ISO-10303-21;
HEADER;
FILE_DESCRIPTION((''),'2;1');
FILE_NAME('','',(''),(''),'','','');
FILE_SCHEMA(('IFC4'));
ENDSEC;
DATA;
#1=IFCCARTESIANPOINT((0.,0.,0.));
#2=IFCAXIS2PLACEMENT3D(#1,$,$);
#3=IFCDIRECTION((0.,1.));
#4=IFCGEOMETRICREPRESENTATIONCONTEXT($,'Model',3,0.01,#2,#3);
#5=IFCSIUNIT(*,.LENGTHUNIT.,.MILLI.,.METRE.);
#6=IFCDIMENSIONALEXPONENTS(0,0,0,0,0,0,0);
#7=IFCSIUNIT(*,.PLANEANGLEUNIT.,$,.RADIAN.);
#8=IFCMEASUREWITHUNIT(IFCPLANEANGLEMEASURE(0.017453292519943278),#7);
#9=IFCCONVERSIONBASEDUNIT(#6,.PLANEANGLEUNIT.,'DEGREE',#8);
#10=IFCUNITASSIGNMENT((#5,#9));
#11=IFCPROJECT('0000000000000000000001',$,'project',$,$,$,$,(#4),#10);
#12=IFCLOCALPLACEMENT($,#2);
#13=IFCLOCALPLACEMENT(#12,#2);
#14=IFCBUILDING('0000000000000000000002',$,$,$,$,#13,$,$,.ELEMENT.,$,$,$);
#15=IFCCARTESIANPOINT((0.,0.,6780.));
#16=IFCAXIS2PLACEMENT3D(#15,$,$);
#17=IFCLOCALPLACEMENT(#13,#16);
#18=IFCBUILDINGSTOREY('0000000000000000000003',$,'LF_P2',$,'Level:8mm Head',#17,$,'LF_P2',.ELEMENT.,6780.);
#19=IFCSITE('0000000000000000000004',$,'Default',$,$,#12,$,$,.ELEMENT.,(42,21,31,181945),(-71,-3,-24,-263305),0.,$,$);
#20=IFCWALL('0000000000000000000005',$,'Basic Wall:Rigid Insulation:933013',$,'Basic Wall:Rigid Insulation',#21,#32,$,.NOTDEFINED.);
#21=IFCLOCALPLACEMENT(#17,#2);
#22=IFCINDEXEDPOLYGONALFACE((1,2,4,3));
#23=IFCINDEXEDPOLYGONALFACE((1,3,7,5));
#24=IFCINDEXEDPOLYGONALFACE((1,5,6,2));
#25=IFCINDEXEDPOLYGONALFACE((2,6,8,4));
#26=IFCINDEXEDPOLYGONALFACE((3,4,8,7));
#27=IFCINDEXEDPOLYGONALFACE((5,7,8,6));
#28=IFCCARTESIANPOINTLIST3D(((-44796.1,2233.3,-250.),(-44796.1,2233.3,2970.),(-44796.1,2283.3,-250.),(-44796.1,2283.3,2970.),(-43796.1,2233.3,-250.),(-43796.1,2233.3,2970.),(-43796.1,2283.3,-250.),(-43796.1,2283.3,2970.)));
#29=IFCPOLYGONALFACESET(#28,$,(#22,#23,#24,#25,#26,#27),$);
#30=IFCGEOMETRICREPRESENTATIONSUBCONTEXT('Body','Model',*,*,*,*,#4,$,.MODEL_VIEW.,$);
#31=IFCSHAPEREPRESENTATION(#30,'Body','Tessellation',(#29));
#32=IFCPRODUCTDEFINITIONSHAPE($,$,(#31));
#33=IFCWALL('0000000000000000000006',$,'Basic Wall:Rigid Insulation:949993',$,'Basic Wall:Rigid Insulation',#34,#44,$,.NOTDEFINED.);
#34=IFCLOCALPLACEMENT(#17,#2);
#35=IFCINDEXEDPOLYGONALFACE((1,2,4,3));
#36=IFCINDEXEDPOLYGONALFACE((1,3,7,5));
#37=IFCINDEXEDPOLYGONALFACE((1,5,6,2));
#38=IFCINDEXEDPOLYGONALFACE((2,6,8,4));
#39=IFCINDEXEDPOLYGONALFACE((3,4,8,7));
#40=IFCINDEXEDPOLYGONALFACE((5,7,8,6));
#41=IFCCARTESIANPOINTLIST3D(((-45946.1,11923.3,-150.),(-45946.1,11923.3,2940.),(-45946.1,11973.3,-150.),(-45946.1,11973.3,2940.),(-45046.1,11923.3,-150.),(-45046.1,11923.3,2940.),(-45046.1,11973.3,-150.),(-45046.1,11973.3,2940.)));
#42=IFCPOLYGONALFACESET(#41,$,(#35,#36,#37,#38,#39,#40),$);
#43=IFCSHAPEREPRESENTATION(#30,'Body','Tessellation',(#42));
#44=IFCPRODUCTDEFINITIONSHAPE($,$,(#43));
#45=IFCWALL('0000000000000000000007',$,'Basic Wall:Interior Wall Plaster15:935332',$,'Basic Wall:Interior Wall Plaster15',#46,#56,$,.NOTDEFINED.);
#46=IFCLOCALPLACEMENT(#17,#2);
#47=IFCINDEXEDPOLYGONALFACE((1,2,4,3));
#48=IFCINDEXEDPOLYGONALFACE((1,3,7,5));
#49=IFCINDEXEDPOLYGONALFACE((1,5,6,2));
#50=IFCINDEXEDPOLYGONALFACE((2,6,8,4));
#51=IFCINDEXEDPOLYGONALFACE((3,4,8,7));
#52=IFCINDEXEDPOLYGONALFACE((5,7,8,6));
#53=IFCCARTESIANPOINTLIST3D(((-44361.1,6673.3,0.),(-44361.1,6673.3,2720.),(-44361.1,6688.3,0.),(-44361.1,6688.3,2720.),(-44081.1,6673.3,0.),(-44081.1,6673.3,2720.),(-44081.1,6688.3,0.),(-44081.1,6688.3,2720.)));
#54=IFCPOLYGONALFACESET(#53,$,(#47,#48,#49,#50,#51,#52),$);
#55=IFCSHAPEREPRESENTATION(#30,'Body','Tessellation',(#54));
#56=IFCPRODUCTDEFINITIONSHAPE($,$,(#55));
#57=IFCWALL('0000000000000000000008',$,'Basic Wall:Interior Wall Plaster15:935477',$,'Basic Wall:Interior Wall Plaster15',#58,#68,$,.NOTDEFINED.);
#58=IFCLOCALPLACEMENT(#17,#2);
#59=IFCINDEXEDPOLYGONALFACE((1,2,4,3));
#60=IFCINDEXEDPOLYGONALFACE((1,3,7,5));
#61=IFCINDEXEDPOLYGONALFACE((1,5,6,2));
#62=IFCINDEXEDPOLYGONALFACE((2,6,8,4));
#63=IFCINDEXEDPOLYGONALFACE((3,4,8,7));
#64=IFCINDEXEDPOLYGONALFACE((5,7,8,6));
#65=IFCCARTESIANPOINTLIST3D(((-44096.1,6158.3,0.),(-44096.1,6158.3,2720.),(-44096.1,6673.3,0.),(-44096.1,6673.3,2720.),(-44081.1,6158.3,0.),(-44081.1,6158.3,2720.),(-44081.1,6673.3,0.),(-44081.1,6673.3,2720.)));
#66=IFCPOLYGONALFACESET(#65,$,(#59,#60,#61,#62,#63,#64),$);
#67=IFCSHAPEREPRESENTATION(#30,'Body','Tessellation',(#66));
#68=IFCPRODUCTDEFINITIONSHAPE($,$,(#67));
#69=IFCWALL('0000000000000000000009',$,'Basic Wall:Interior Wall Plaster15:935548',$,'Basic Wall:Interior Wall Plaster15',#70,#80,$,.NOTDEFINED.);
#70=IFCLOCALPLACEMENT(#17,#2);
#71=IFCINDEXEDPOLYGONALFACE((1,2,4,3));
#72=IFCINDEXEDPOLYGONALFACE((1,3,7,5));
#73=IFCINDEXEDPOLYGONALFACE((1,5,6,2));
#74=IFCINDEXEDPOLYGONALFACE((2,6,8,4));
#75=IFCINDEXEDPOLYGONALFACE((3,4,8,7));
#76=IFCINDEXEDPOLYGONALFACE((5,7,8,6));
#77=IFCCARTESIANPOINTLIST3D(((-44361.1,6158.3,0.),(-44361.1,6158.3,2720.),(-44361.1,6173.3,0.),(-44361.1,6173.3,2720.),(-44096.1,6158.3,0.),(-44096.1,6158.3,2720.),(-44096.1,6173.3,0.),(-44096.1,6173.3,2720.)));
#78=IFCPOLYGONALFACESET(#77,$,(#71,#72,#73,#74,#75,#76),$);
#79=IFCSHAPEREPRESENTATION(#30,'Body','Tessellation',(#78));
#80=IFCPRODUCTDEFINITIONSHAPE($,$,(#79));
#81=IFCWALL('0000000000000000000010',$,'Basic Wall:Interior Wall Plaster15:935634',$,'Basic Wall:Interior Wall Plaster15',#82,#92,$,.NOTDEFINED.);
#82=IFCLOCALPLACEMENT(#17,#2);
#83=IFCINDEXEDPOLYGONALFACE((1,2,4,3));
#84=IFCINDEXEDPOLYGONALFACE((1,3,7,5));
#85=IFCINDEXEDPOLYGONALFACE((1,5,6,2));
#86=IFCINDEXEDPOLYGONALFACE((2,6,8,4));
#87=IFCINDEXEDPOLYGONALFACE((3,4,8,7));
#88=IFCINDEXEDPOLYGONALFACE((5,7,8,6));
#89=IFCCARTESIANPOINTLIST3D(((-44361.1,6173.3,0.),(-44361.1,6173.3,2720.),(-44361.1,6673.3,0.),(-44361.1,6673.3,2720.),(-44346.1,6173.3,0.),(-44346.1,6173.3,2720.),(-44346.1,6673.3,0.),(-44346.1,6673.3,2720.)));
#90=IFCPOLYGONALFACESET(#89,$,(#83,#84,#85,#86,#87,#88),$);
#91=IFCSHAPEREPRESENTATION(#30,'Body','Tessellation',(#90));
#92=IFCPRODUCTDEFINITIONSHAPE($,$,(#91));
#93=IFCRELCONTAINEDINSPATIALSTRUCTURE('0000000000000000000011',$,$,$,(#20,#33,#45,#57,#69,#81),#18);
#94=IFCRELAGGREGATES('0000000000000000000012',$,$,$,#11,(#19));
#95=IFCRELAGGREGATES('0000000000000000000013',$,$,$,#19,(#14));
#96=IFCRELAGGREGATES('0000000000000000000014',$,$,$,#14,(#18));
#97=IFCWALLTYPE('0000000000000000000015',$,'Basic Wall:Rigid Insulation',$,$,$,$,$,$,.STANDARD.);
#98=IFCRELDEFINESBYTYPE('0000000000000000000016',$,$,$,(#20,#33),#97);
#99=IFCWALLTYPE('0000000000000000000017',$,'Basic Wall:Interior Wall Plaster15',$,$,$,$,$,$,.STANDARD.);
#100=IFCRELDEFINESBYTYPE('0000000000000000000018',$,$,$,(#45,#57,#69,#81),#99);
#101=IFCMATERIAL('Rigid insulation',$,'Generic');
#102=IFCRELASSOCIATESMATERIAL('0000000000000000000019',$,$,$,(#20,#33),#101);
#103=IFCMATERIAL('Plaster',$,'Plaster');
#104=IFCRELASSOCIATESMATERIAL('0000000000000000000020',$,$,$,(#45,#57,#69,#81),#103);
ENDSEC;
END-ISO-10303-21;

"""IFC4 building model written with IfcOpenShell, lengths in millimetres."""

from ifc_helpers import new_model, entity, si_unit, converted_unit, direction, frame, origin, place, context, subcontext, project, spatial, indexed_curve, outline, extrude, material, type_object, element, save


model = new_model("IFC4")

# Units and contexts
model_context = context("Model", 3, precision=0.01, world=origin(), true_north=direction((0.0, 1.0)))
body_context = subcontext(model_context, "Body", "Model", "MODEL_VIEW")
ifc_project = project(units=[si_unit("LENGTHUNIT", "METRE", prefix="MILLI"), converted_unit("PLANEANGLEUNIT", "DEGREE", entity("IfcPlaneAngleMeasure", 0.017453292519943278), si_unit("PLANEANGLEUNIT", "RADIAN"), dimensions=[0, 0, 0, 0, 0, 0, 0])], contexts=[model_context])

# Site, building, storey
site_placement = place(None, origin())
site = spatial("IfcSite", under=ifc_project, at=site_placement, Name="Default", CompositionType="ELEMENT", RefLatitude=(42, 21, 31, 181945), RefLongitude=(-71, -3, -24, -263305), RefElevation=0.0)
building_placement = place(site_placement, origin())
building = spatial("IfcBuilding", under=site, at=building_placement, CompositionType="ELEMENT")
storey_placement = place(building_placement, frame((0.0, 0.0, 6780.0)))
storey = spatial("IfcBuildingStorey", under=building, at=storey_placement, Name="LF_P2", ObjectType="Level:8mm Head", LongName="LF_P2", CompositionType="ELEMENT", Elevation=6780.0)

# Walls
ifc_material_1 = material(Name="Rigid insulation", Category="Generic")
ifc_material_2 = material(Name="Plaster", Category="Plaster")
wall_type_1 = type_object("IfcWallType", Name="Basic Wall:Rigid Insulation", PredefinedType="STANDARD")
wall_1_placement = place(storey_placement, frame((-44796.1, 2258.3, -250.0)))
element("IfcWall", 1, at=wall_1_placement, inside=storey, type_object=wall_type_1, material=ifc_material_1, Name="Basic Wall:Rigid Insulation:933013", ObjectType="Basic Wall:Rigid Insulation", PredefinedType="NOTDEFINED", context=body_context, shape_type="SweptSolid", body=[
    extrude(outline(indexed_curve([(1000.0, 25.0), (0.0, 25.0), (0.0, -25.0), (1000.0, -25.0), (1000.0, 25.0)], self_intersect=False)), origin(), (0.0, 0.0, 1.0), 3220.0),
])
wall_2_placement = place(storey_placement, frame((-45946.1, 11948.3, -150.0)))
element("IfcWall", 2, at=wall_2_placement, inside=storey, type_object=wall_type_1, material=ifc_material_1, Name="Basic Wall:Rigid Insulation:949993", ObjectType="Basic Wall:Rigid Insulation", PredefinedType="NOTDEFINED", context=body_context, shape_type="SweptSolid", body=[
    extrude(outline(indexed_curve([(900.0, 25.0), (0.0, 25.0), (0.0, -25.0), (900.0, -25.0), (900.0, 25.0)], self_intersect=False)), origin(), (0.0, 0.0, 1.0), 3090.0),
])
wall_type_2 = type_object("IfcWallType", Name="Basic Wall:Interior Wall Plaster15", PredefinedType="STANDARD")
wall_3_placement = place(storey_placement, frame((-44361.1, 6680.8, 0.0)))
element("IfcWall", 3, at=wall_3_placement, inside=storey, type_object=wall_type_2, material=ifc_material_2, Name="Basic Wall:Interior Wall Plaster15:935332", ObjectType="Basic Wall:Interior Wall Plaster15", PredefinedType="NOTDEFINED", context=body_context, shape_type="SweptSolid", body=[
    extrude(outline(indexed_curve([(280.0, 7.5), (0.0, 7.5), (0.0, -7.5), (280.0, -7.5), (280.0, 7.5)], self_intersect=False)), origin(), (0.0, 0.0, 1.0), 2720.0),
])
wall_4_placement = place(storey_placement, frame((-44088.6, 6673.3, 0.0), z_axis=(0.0, 0.0, 1.0), x_axis=(0.0, -1.0, 0.0)))
element("IfcWall", 4, at=wall_4_placement, inside=storey, type_object=wall_type_2, material=ifc_material_2, Name="Basic Wall:Interior Wall Plaster15:935477", ObjectType="Basic Wall:Interior Wall Plaster15", PredefinedType="NOTDEFINED", context=body_context, shape_type="SweptSolid", body=[
    extrude(outline(indexed_curve([(515.0, 7.5), (0.0, 7.5), (0.0, -7.5), (515.0, -7.5), (515.0, 7.5)], self_intersect=False)), origin(), (0.0, 0.0, 1.0), 2720.0),
])
wall_5_placement = place(storey_placement, frame((-44096.1, 6165.8, 0.0), z_axis=(0.0, 0.0, 1.0), x_axis=(-1.0, 0.0, 0.0)))
element("IfcWall", 5, at=wall_5_placement, inside=storey, type_object=wall_type_2, material=ifc_material_2, Name="Basic Wall:Interior Wall Plaster15:935548", ObjectType="Basic Wall:Interior Wall Plaster15", PredefinedType="NOTDEFINED", context=body_context, shape_type="SweptSolid", body=[
    extrude(outline(indexed_curve([(265.0, 7.5), (0.0, 7.5), (0.0, -7.5), (265.0, -7.5), (265.0, 7.5)], self_intersect=False)), origin(), (0.0, 0.0, 1.0), 2720.0),
])
wall_6_placement = place(storey_placement, frame((-44353.6, 6173.3, 0.0), z_axis=(0.0, 0.0, 1.0), x_axis=(0.0, 1.0, 0.0)))
element("IfcWall", 6, at=wall_6_placement, inside=storey, type_object=wall_type_2, material=ifc_material_2, Name="Basic Wall:Interior Wall Plaster15:935634", ObjectType="Basic Wall:Interior Wall Plaster15", PredefinedType="NOTDEFINED", context=body_context, shape_type="SweptSolid", body=[
    extrude(outline(indexed_curve([(500.0, 7.5), (0.0, 7.5), (0.0, -7.5), (500.0, -7.5), (500.0, 7.5)], self_intersect=False)), origin(), (0.0, 0.0, 1.0), 2720.0),
])

save(model, "model.ifc")
